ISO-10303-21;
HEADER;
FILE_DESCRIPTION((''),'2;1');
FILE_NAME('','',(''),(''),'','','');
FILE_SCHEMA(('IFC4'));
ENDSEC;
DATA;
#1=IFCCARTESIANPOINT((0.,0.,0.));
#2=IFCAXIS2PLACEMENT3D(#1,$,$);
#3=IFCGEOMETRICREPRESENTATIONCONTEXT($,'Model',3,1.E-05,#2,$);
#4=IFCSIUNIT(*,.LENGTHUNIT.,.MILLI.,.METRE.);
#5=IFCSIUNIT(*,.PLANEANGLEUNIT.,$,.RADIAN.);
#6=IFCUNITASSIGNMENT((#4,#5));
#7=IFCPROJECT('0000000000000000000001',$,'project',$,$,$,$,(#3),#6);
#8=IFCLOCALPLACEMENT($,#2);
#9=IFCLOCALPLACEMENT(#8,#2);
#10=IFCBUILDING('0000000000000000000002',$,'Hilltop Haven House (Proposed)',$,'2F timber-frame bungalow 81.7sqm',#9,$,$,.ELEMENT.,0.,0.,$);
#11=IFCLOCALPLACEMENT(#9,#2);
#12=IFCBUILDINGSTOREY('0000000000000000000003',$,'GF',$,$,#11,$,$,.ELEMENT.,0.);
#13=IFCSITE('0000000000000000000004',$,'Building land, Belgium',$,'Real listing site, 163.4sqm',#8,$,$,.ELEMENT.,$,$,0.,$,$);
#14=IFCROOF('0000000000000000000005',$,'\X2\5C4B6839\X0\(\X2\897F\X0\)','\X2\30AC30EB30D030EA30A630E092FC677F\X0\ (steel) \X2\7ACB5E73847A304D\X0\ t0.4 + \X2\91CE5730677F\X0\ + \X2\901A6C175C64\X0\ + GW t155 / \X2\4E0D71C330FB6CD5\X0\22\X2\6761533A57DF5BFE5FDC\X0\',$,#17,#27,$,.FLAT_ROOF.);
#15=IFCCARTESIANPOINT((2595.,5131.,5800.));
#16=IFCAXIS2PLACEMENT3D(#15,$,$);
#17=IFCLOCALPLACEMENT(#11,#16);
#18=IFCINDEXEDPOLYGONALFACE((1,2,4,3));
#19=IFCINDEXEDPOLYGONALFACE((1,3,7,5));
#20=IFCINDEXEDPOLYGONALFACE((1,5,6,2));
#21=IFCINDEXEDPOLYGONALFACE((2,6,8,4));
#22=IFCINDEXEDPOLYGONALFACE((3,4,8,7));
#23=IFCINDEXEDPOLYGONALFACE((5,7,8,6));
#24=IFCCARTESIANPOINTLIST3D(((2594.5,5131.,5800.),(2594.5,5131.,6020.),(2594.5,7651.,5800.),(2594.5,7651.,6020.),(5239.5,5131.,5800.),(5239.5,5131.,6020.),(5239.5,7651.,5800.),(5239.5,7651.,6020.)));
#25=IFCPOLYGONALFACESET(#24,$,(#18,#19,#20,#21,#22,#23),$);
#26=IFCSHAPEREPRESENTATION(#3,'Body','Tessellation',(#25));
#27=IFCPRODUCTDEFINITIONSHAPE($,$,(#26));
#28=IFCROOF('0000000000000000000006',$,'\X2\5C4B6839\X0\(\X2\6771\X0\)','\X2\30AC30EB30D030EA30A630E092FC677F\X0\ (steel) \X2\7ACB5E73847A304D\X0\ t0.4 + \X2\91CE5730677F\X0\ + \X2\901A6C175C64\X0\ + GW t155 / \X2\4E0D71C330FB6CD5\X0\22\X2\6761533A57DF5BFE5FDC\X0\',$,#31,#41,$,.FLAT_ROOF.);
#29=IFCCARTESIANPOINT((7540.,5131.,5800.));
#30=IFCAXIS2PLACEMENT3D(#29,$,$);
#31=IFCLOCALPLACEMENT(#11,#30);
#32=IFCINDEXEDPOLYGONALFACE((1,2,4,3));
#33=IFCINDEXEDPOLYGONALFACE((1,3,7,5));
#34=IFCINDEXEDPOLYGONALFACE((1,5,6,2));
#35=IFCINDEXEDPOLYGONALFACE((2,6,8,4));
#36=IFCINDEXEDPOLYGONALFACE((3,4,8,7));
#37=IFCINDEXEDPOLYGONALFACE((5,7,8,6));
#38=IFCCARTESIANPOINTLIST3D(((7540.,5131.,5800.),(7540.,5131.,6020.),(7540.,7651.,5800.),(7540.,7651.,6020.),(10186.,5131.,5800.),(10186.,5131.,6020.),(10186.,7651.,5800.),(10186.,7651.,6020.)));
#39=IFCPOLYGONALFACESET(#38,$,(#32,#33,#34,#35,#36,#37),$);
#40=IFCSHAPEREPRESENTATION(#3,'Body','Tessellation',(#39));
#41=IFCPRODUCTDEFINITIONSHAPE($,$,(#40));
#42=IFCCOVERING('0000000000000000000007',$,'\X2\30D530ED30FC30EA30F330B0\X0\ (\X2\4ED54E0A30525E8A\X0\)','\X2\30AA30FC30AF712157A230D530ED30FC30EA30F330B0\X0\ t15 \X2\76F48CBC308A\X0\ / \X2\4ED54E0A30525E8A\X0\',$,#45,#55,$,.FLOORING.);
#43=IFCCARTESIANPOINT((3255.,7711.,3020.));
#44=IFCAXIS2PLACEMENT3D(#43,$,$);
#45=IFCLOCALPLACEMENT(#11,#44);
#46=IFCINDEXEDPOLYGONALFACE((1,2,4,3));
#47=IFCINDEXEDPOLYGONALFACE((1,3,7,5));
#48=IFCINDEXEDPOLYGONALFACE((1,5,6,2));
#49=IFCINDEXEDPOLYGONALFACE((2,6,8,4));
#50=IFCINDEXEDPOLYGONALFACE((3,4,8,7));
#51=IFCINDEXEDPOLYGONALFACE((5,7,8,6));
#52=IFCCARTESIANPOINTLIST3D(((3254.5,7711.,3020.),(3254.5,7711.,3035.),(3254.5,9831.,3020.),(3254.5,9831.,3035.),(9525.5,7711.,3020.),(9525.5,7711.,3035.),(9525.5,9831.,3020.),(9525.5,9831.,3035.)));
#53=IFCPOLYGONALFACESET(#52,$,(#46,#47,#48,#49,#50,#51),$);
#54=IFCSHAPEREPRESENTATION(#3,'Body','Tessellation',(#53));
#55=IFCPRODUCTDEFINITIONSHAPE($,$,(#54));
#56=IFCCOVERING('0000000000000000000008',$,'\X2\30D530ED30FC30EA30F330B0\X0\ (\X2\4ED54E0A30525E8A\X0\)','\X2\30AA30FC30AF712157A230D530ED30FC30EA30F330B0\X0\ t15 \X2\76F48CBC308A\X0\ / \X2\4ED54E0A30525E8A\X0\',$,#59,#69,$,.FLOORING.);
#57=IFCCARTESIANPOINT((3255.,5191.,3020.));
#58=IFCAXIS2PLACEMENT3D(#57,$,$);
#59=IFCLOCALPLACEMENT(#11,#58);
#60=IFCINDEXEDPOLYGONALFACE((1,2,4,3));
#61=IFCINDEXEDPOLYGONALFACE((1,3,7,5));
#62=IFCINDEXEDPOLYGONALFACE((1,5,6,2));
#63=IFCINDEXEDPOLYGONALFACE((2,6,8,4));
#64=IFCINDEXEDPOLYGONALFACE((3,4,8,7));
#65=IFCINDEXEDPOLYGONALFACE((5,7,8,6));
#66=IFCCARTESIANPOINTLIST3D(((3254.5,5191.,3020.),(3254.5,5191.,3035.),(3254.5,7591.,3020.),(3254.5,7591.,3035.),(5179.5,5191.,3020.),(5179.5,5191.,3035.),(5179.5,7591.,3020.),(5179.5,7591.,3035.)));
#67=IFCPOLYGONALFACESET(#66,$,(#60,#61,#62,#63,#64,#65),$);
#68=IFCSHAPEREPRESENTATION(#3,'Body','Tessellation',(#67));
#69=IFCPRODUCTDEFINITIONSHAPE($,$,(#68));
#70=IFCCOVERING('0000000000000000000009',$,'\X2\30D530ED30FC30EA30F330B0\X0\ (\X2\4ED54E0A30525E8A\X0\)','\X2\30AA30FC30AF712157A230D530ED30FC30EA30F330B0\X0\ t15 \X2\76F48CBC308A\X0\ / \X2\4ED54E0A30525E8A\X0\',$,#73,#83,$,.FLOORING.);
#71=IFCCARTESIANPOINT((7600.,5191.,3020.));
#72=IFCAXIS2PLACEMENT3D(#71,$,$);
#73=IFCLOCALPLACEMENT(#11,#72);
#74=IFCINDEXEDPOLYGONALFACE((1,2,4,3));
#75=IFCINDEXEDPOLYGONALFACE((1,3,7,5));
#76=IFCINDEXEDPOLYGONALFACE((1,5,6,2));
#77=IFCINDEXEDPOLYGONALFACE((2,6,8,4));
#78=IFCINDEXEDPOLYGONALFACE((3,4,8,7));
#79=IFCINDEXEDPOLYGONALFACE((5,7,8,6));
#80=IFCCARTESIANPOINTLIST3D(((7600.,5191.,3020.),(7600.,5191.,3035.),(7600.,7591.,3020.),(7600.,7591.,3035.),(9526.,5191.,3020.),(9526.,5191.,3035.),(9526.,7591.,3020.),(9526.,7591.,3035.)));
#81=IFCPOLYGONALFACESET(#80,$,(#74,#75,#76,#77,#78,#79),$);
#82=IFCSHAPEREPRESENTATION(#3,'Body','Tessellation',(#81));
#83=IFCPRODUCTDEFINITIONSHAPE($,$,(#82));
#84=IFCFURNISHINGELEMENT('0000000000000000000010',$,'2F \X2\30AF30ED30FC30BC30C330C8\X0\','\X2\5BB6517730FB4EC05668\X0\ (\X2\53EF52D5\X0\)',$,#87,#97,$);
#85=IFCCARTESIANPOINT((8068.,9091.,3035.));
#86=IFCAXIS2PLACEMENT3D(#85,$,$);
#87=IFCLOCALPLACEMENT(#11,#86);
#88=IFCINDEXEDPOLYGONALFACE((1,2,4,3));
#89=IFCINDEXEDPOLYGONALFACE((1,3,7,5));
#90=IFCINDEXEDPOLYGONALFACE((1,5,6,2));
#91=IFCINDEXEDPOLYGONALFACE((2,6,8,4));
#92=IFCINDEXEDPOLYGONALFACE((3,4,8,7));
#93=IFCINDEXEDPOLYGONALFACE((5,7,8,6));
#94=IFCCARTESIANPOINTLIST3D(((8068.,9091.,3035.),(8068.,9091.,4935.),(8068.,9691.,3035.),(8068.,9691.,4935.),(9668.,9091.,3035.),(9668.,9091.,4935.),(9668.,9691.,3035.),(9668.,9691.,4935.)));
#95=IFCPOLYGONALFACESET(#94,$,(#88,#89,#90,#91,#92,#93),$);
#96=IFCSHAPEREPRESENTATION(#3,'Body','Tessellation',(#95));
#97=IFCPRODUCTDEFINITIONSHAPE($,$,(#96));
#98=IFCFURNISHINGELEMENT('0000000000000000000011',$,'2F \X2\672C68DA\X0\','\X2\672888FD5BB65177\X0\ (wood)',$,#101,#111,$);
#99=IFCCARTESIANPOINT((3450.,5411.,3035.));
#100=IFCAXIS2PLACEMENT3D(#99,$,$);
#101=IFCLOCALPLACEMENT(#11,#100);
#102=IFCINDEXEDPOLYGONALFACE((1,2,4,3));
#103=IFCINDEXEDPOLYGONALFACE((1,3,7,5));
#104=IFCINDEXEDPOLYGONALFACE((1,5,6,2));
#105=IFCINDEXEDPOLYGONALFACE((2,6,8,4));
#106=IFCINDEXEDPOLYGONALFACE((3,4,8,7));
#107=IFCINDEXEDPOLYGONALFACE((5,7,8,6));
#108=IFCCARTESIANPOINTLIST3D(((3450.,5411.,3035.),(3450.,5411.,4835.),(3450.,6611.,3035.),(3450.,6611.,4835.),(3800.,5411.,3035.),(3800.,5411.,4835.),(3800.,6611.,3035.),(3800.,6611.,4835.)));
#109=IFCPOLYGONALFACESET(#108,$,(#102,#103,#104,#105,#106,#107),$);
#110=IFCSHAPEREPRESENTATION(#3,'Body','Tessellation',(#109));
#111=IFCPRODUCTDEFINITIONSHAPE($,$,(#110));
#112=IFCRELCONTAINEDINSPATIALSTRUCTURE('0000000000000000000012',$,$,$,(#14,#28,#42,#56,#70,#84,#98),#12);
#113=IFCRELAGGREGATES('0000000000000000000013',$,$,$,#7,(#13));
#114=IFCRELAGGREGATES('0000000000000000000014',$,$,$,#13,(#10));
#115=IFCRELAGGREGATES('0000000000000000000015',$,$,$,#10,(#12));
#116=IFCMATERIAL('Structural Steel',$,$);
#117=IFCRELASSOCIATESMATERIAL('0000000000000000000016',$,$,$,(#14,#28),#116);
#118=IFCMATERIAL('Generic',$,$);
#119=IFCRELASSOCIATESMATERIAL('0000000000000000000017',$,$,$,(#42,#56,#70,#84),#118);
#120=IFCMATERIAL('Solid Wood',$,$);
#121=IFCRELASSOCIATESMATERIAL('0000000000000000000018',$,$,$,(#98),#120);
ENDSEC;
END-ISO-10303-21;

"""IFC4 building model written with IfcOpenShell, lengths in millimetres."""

from ifc_helpers import new_model, si_unit, frame, frame_2d, origin, place, context, project, spatial, rectangle, extrude, material, element, save


model = new_model("IFC4")

# Units and contexts
model_context = context("Model", 3, precision=1e-05, world=origin())
ifc_project = project(units=[si_unit("LENGTHUNIT", "METRE", prefix="MILLI"), si_unit("PLANEANGLEUNIT", "RADIAN")], contexts=[model_context])

# Site, building, storey
site_placement = place(None, origin())
site = spatial("IfcSite", under=ifc_project, at=site_placement, Name="Building land, Belgium", ObjectType="Real listing site, 163.4sqm", CompositionType="ELEMENT", RefElevation=0.0)
building_placement = place(site_placement, origin())
building = spatial("IfcBuilding", under=site, at=building_placement, Name="Hilltop Haven House (Proposed)", ObjectType="2F timber-frame bungalow 81.7sqm", CompositionType="ELEMENT", ElevationOfRefHeight=0.0, ElevationOfTerrain=0.0)
storey_placement = place(building_placement, origin())
storey = spatial("IfcBuildingStorey", under=building, at=storey_placement, Name="GF", CompositionType="ELEMENT", Elevation=0.0)

# Shared definitions
ifc_material_1 = material(Name="Solid Wood")

# Roofs
ifc_material_2 = material(Name="Structural Steel")
roof_1_placement = place(storey_placement, frame((2595.0, 5131.0, 5800.0)))
element("IfcRoof", 1, at=roof_1_placement, inside=storey, material=ifc_material_2, Name="屋根(西)", Description="ガルバリウム鋼板 (steel) 立平葺き t0.4 + 野地板 + 通気層 + GW t155 / 不燃・法22条区域対応", PredefinedType="FLAT_ROOF", context=model_context, shape_type="SweptSolid", body=[
    extrude(rectangle(XDim=2645.0, YDim=2520.0, at=frame_2d((1322.0, 1260.0))), frame((2595.0, 5131.0, 5800.0)), (0.0, 0.0, 1.0), 220.0),
])
roof_2_placement = place(storey_placement, frame((7540.0, 5131.0, 5800.0)))
element("IfcRoof", 2, at=roof_2_placement, inside=storey, material=ifc_material_2, Name="屋根(東)", Description="ガルバリウム鋼板 (steel) 立平葺き t0.4 + 野地板 + 通気層 + GW t155 / 不燃・法22条区域対応", PredefinedType="FLAT_ROOF", context=model_context, shape_type="SweptSolid", body=[
    extrude(rectangle(XDim=2646.0, YDim=2520.0, at=frame_2d((1323.0, 1260.0))), frame((7540.0, 5131.0, 5800.0)), (0.0, 0.0, 1.0), 220.0),
])

# Coverings
ifc_material_3 = material(Name="Generic")
covering_1_placement = place(storey_placement, frame((3255.0, 7711.0, 3020.0)))
element("IfcCovering", 3, at=covering_1_placement, inside=storey, material=ifc_material_3, Name="フローリング (仕上げ床)", Description="オーク無垢フローリング t15 直貼り / 仕上げ床", PredefinedType="FLOORING", context=model_context, shape_type="SweptSolid", body=[
    extrude(rectangle(XDim=6271.0, YDim=2120.0, at=frame_2d((3135.0, 1060.0))), frame((3255.0, 7711.0, 3020.0)), (0.0, 0.0, 1.0), 15.0),
])
covering_2_placement = place(storey_placement, frame((3255.0, 5191.0, 3020.0)))
element("IfcCovering", 4, at=covering_2_placement, inside=storey, material=ifc_material_3, Name="フローリング (仕上げ床)", Description="オーク無垢フローリング t15 直貼り / 仕上げ床", PredefinedType="FLOORING", context=model_context, shape_type="SweptSolid", body=[
    extrude(rectangle(XDim=1925.0, YDim=2400.0, at=frame_2d((962.0, 1200.0))), frame((3255.0, 5191.0, 3020.0)), (0.0, 0.0, 1.0), 15.0),
])
covering_3_placement = place(storey_placement, frame((7600.0, 5191.0, 3020.0)))
element("IfcCovering", 5, at=covering_3_placement, inside=storey, material=ifc_material_3, Name="フローリング (仕上げ床)", Description="オーク無垢フローリング t15 直貼り / 仕上げ床", PredefinedType="FLOORING", context=model_context, shape_type="SweptSolid", body=[
    extrude(rectangle(XDim=1926.0, YDim=2400.0, at=frame_2d((963.0, 1200.0))), frame((7600.0, 5191.0, 3020.0)), (0.0, 0.0, 1.0), 15.0),
])

# Furnishing elements
furnishing_1_placement = place(storey_placement, frame((8068.0, 9091.0, 3035.0)))
element("IfcFurnishingElement", 6, at=furnishing_1_placement, inside=storey, material=ifc_material_3, Name="2F クローゼット", Description="家具・什器 (可動)", context=model_context, shape_type="SweptSolid", body=[
    extrude(rectangle(XDim=1600.0, YDim=600.0, at=frame_2d((800.0, 300.0))), frame((8068.0, 9091.0, 3035.0)), (0.0, 0.0, 1.0), 1900.0),
])
furnishing_2_placement = place(storey_placement, frame((3450.0, 5411.0, 3035.0)))
element("IfcFurnishingElement", 7, at=furnishing_2_placement, inside=storey, material=ifc_material_1, Name="2F 本棚", Description="木製家具 (wood)", context=model_context, shape_type="SweptSolid", body=[
    extrude(rectangle(XDim=350.0, YDim=1200.0, at=frame_2d((175.0, 600.0))), frame((3450.0, 5411.0, 3035.0)), (0.0, 0.0, 1.0), 1800.0),
])

save(model, "model.ifc")
